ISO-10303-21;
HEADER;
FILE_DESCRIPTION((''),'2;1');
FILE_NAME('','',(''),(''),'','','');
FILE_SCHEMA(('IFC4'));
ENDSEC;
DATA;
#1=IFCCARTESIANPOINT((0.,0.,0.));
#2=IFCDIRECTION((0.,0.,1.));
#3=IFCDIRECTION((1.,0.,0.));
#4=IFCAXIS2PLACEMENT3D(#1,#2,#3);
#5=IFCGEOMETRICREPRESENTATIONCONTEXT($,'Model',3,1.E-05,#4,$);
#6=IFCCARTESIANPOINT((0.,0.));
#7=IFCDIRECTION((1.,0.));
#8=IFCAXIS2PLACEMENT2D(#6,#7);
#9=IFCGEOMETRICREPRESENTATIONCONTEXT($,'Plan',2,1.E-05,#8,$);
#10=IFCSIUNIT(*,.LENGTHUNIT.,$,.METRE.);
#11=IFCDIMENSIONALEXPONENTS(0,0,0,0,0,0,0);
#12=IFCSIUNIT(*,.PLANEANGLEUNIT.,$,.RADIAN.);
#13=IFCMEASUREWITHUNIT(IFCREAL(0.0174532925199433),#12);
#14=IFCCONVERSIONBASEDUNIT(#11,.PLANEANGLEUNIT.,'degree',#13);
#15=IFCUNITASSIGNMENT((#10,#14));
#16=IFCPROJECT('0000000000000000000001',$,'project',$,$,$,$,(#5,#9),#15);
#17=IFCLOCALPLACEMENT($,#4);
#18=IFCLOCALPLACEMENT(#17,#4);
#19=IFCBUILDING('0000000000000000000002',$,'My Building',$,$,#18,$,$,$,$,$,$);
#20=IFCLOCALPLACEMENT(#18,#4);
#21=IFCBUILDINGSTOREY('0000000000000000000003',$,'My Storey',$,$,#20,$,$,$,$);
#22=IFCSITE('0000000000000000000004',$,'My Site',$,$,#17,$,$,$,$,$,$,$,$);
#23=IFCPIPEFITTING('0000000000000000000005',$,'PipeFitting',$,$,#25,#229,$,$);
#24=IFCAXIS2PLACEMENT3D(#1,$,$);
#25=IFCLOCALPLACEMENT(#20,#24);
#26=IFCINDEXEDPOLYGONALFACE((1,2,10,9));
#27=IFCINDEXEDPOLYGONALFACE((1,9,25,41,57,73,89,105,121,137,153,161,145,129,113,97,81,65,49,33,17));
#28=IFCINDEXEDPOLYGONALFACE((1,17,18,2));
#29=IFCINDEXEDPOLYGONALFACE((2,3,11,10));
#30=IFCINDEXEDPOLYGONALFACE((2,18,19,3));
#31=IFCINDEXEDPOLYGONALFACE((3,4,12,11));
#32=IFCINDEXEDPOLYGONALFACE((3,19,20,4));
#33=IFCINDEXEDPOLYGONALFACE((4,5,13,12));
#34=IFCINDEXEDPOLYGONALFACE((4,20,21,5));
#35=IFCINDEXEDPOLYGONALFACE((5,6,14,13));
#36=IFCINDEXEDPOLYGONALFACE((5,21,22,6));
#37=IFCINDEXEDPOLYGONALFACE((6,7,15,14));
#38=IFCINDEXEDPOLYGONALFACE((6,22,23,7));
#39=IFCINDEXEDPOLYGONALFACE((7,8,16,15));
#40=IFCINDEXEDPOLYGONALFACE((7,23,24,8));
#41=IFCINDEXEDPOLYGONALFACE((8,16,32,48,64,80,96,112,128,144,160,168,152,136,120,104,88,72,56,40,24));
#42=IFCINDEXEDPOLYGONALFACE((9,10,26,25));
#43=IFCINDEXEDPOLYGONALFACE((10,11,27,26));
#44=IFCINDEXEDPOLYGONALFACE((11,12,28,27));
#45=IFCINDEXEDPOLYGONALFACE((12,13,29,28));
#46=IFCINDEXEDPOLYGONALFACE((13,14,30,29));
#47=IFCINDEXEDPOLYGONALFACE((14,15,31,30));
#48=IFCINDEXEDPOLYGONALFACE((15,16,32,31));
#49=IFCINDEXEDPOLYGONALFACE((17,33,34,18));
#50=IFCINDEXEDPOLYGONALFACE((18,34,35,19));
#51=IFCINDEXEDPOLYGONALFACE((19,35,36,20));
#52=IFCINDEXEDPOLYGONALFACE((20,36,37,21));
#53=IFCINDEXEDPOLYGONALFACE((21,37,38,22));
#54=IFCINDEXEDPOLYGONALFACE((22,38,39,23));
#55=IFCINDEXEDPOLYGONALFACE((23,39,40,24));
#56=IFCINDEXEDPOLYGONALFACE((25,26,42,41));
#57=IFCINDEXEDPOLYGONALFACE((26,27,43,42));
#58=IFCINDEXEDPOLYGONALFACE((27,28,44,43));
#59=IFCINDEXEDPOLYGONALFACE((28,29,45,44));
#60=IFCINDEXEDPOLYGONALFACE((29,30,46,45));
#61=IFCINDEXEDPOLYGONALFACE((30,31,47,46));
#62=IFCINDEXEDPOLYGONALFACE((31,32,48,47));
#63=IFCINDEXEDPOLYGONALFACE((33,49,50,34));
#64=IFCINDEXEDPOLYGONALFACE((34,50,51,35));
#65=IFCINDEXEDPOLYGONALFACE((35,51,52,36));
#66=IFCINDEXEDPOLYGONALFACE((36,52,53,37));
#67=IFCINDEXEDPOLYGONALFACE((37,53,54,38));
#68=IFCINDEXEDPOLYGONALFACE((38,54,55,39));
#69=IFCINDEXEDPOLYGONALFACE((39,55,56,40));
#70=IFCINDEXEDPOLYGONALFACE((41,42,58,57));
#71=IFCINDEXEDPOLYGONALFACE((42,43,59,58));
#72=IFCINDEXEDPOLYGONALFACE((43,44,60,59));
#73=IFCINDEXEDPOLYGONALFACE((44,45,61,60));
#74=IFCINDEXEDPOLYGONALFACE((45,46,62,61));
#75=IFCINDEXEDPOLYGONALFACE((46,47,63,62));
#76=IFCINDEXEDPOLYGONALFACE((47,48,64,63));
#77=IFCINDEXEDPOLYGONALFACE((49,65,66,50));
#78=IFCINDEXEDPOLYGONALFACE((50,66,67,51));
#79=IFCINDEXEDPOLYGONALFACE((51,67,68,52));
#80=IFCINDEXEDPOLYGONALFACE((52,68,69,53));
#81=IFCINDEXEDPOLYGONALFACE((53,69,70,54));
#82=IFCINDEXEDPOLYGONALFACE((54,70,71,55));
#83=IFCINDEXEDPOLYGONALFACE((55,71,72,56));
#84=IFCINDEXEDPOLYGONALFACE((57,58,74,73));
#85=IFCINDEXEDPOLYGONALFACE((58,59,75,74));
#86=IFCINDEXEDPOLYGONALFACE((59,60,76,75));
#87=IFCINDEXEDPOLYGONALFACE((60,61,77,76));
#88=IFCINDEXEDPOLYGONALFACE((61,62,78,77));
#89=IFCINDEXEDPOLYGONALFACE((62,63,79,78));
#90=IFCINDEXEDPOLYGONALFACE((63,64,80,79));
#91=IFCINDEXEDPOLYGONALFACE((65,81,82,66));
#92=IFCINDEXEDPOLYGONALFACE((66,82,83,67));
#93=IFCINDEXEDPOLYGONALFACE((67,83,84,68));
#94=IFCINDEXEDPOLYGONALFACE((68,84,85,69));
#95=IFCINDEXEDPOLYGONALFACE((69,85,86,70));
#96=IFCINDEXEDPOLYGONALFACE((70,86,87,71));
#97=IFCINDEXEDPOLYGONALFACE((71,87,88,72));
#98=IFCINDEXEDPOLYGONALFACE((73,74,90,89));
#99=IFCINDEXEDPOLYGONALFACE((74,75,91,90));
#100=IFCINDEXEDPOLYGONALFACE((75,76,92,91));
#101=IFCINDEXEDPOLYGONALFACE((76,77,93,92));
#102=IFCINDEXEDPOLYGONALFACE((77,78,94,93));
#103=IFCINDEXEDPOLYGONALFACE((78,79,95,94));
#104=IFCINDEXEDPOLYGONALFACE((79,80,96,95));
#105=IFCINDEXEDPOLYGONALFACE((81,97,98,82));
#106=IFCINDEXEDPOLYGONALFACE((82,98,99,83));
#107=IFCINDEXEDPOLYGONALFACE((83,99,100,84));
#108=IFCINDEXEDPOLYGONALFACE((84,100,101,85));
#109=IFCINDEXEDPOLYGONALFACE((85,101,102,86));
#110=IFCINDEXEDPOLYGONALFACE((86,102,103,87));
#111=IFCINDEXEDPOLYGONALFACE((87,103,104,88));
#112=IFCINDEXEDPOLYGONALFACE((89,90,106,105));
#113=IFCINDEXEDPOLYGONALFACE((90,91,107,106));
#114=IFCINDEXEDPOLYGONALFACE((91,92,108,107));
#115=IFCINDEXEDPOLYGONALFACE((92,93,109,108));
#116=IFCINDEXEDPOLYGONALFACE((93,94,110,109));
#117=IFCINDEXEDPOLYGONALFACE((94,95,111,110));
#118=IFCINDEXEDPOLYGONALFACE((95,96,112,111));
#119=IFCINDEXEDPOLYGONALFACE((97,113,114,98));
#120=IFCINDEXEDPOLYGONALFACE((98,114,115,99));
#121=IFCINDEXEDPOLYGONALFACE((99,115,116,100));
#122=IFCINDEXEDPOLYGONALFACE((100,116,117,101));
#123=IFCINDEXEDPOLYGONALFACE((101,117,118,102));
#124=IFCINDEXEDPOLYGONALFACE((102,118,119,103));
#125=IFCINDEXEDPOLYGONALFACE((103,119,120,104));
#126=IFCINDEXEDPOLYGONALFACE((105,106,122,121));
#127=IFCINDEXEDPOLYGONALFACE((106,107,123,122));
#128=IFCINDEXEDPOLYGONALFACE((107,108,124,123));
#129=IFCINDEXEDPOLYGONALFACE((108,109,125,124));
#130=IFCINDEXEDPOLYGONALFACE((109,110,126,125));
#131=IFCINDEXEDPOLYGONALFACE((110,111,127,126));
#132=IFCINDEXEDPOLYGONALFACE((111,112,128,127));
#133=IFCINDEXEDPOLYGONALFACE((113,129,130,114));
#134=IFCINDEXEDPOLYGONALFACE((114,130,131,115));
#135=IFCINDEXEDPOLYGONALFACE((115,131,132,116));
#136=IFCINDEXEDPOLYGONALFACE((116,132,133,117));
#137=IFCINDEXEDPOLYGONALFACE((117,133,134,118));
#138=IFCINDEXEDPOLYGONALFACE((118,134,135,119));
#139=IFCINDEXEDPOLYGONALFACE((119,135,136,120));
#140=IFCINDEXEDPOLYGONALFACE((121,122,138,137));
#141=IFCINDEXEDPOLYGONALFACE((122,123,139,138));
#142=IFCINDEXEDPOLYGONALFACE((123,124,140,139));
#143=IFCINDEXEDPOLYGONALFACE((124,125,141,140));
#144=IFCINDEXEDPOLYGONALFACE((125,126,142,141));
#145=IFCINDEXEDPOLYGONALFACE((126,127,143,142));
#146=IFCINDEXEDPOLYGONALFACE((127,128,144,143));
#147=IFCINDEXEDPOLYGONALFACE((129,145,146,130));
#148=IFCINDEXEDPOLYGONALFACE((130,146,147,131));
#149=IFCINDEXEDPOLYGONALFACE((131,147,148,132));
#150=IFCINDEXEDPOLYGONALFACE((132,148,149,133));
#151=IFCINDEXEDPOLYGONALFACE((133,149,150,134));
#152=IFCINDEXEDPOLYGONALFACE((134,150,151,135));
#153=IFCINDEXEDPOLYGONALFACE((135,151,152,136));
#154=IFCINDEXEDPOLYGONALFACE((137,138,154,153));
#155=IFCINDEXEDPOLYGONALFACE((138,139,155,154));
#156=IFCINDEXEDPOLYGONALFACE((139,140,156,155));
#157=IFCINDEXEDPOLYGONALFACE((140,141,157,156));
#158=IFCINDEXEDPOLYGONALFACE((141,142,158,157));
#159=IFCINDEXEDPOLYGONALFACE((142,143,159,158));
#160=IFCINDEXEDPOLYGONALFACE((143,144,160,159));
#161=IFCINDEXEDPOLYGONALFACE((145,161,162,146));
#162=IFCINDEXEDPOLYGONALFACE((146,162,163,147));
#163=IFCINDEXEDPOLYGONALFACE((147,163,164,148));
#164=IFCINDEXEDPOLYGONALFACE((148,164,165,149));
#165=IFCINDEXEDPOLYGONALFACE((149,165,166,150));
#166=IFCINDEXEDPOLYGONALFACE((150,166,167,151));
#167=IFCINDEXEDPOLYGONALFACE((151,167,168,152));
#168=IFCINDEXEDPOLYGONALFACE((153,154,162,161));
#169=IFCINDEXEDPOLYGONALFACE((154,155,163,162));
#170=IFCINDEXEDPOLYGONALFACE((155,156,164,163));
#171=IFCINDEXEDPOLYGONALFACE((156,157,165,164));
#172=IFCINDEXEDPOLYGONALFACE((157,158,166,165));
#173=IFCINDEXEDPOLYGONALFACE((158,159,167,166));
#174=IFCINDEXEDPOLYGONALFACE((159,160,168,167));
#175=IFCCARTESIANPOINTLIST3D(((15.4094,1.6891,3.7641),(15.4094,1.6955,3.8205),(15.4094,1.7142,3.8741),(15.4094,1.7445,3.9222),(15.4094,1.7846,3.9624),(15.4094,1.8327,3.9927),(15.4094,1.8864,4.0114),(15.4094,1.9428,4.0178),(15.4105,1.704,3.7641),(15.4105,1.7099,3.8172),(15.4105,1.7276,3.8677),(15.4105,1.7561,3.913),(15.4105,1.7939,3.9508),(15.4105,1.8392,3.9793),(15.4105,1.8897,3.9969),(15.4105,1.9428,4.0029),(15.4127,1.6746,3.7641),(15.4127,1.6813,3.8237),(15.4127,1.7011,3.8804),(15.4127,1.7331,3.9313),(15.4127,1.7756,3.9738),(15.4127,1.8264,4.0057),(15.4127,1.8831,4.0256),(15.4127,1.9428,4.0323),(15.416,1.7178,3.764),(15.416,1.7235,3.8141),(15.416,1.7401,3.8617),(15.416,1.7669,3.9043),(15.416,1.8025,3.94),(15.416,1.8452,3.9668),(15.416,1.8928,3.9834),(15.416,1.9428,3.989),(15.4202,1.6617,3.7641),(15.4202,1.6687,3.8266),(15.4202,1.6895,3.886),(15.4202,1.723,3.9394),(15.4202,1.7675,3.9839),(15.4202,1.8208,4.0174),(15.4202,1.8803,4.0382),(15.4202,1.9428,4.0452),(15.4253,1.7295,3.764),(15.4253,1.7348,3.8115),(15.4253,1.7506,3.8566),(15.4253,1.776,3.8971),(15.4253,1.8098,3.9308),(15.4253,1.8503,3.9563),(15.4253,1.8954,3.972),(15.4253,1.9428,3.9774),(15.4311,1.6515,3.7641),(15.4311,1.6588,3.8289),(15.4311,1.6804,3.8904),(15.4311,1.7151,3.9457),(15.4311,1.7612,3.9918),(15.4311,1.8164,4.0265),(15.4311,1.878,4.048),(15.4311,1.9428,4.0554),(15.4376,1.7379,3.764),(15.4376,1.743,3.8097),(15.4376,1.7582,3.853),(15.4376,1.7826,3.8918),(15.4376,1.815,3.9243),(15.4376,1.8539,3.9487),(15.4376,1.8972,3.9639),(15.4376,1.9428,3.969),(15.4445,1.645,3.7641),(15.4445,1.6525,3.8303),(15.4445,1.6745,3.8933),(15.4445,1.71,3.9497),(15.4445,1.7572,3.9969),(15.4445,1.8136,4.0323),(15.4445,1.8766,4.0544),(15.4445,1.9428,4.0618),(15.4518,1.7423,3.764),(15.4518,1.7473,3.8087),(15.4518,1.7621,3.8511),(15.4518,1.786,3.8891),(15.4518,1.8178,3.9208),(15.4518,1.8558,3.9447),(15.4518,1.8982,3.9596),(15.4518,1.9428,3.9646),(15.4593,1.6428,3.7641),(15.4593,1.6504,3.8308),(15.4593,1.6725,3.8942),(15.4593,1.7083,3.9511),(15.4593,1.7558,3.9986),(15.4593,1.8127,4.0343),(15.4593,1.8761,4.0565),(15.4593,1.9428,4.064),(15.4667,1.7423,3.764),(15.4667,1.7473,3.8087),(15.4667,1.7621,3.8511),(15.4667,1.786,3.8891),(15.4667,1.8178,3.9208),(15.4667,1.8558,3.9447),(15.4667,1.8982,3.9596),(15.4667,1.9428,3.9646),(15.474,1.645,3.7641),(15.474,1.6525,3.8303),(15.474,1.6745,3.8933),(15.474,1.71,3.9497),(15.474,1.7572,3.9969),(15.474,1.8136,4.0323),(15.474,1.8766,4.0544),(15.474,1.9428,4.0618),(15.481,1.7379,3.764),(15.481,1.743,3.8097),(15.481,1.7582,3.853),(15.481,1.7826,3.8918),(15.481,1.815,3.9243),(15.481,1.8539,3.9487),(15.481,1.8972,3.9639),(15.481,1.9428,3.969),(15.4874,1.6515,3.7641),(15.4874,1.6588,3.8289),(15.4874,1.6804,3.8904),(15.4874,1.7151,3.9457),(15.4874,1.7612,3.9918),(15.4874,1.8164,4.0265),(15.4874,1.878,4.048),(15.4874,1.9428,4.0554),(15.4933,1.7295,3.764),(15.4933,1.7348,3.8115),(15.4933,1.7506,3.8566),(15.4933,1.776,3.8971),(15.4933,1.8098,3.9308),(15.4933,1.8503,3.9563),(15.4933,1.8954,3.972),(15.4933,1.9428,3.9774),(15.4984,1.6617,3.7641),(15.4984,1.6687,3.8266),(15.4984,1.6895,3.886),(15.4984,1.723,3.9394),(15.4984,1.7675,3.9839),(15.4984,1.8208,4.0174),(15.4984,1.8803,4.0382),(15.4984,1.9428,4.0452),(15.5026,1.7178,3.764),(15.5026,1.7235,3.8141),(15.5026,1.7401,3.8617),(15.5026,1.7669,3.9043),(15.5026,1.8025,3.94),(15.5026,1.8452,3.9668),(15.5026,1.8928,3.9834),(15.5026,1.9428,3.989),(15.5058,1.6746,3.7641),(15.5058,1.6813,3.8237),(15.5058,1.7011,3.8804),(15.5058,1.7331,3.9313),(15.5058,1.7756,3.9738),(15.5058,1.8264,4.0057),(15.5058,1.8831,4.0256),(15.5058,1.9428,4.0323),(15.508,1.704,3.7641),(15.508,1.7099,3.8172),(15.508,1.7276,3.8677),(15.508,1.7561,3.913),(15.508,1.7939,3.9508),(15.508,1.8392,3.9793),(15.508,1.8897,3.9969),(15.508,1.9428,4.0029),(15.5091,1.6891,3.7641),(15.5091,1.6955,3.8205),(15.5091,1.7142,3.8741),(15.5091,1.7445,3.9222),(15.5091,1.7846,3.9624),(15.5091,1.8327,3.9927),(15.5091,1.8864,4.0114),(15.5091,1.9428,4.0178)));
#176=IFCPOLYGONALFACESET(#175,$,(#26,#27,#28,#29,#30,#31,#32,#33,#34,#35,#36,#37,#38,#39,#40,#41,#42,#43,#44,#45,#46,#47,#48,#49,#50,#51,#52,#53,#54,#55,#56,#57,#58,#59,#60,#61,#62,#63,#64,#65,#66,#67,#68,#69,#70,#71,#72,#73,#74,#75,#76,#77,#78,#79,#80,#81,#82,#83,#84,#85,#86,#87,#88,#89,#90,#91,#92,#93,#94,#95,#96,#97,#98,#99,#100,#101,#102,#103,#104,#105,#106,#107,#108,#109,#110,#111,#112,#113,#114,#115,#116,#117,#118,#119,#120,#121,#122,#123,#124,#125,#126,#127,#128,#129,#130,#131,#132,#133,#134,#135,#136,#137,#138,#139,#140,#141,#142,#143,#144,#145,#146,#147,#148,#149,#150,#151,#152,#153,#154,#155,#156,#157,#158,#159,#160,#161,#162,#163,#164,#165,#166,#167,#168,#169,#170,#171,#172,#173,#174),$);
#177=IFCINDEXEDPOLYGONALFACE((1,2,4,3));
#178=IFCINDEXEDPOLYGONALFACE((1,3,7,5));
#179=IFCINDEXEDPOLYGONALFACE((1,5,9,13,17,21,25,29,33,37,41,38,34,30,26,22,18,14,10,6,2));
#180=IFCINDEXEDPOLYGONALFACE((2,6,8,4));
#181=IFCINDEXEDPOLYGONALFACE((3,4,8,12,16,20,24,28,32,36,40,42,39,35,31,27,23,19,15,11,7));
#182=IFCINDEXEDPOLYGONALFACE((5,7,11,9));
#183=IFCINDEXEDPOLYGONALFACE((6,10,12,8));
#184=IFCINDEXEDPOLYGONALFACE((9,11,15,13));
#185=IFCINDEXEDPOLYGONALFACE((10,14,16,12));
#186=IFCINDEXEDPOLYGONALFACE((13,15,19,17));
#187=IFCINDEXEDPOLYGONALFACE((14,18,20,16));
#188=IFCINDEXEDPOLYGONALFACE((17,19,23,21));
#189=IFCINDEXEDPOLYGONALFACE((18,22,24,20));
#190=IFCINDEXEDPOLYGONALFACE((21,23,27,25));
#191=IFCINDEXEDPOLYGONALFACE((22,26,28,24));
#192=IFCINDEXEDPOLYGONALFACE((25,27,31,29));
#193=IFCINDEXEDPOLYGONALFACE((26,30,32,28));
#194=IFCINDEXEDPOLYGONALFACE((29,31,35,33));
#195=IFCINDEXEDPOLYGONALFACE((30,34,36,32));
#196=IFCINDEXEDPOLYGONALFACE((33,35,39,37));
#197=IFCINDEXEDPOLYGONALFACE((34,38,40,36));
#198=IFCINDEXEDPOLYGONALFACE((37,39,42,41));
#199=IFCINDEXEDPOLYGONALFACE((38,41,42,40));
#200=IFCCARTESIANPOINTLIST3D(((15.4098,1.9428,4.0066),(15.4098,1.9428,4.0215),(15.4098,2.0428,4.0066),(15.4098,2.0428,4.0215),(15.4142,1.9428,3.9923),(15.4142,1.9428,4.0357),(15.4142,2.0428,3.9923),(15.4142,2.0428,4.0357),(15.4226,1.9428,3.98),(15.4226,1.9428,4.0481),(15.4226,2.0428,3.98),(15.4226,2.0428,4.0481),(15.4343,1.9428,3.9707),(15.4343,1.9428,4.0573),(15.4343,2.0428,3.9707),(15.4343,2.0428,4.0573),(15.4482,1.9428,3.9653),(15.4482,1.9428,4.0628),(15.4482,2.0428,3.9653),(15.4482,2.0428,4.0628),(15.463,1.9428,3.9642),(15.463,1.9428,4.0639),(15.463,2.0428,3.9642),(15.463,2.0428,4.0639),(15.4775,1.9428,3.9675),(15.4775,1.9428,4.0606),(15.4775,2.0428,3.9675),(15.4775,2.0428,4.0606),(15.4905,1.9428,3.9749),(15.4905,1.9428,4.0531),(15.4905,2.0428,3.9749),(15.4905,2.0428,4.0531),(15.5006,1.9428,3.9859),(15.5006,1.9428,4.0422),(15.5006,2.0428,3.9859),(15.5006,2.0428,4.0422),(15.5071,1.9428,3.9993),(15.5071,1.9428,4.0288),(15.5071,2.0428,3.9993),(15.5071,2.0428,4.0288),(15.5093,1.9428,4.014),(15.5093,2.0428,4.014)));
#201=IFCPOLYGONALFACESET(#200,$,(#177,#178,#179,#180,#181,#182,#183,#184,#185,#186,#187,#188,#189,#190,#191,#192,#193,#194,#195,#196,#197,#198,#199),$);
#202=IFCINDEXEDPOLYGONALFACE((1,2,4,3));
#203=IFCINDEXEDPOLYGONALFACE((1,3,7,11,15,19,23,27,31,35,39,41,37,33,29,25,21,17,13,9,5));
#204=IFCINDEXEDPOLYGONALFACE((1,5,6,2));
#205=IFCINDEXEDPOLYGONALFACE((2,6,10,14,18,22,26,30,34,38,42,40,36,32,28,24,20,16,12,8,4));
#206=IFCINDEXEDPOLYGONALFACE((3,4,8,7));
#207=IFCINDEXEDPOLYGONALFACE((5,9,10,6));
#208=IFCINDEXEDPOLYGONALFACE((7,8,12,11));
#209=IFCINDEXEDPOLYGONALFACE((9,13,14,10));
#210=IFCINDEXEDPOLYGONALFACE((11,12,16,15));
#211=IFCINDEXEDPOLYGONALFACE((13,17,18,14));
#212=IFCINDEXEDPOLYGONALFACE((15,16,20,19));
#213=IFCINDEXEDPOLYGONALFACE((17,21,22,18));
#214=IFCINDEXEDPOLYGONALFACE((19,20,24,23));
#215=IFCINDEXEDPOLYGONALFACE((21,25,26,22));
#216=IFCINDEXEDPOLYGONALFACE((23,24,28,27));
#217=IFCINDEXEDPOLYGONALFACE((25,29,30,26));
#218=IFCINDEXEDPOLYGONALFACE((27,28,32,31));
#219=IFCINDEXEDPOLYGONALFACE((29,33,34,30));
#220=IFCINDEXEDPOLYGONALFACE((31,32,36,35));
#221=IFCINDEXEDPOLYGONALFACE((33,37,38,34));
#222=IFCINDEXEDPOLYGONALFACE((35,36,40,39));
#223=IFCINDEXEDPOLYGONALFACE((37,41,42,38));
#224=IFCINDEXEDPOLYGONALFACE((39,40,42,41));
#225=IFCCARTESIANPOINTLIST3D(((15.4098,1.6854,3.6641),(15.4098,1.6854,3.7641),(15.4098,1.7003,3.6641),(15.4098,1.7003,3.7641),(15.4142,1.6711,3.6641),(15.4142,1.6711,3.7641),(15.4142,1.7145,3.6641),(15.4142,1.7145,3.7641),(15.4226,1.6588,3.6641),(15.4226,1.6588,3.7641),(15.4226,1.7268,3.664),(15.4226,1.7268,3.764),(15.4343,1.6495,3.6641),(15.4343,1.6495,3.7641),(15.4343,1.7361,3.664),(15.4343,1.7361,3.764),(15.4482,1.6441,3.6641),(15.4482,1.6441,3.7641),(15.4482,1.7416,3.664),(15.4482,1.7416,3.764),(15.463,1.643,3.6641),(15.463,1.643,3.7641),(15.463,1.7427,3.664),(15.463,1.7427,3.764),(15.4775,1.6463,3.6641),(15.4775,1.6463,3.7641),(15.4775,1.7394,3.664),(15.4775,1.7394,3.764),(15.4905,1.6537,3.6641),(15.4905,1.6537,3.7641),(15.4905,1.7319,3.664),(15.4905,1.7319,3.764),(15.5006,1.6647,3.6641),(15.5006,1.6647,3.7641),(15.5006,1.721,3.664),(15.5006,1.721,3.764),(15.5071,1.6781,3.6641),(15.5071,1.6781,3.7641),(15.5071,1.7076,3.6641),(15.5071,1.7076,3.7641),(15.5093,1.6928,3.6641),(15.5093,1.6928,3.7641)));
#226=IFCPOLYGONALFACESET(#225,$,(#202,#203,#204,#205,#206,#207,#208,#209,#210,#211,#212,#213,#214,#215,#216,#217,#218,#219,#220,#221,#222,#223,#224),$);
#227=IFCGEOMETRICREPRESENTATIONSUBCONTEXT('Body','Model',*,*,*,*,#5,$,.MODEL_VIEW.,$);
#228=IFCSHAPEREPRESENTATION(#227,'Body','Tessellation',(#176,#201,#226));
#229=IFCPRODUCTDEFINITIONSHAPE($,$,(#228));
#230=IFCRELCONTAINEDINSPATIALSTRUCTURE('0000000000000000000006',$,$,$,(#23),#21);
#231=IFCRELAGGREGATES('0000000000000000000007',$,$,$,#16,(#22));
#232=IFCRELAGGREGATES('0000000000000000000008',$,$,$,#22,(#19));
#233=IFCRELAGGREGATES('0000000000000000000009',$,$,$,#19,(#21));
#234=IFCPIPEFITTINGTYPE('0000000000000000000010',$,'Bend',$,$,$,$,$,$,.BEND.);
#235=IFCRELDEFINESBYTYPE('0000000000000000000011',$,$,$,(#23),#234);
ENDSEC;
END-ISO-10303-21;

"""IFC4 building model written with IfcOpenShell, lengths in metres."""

from ifc_helpers import new_model, entity, si_unit, converted_unit, frame, origin_with_axes, origin_2d_with_axis, place, context, subcontext, project, spatial, circle, extrude, source, transform, mapped, type_object, type_shapes, element, save


model = new_model("IFC4")

# Units and contexts
model_context = context("Model", 3, precision=1e-05, world=origin_with_axes())
plan_context = context("Plan", 2, precision=1e-05, world=origin_2d_with_axis())
body_context_1 = subcontext(model_context, "Body", "Model", "MODEL_VIEW")
ifc_project = project(units=[si_unit("LENGTHUNIT", "METRE"), converted_unit("PLANEANGLEUNIT", "degree", entity("IfcReal", 0.0174532925199433), si_unit("PLANEANGLEUNIT", "RADIAN"), dimensions=[0, 0, 0, 0, 0, 0, 0])], contexts=[model_context, plan_context])

# Site, building, storey
site_placement = place(None, origin_with_axes())
site = spatial("IfcSite", under=ifc_project, at=site_placement, Name="My Site")
building_placement = place(site_placement, origin_with_axes())
building = spatial("IfcBuilding", under=site, at=building_placement, Name="My Building")
storey_placement = place(building_placement, origin_with_axes())
storey = spatial("IfcBuildingStorey", under=building, at=storey_placement, Name="My Storey")

# Pipe fitting
pipe_fitting_type_1 = type_object("IfcPipeFittingType", Name="Bend", PredefinedType="BEND")
shared_shape_1 = source(origin_with_axes(), body_context_1, "Body", "SolidModel", [
    entity("IfcSweptDiskSolid", entity("IfcIndexedPolyCurve", entity("IfcCartesianPointList3D", [[0.0, 0.0, 0.1], [0.0, -0.0732, 0.2768], [0.0, -0.25, 0.35]]), [entity("IfcArcIndex", [1, 2, 3])]), 0.05),
    extrude(circle(Radius=0.05), origin_with_axes(), (0.0, 0.0, 1.0), 0.1),
    extrude(circle(Radius=0.05), frame((0.0, -0.25, 0.35), z_axis=(0.0, -1.0, 0.000038), x_axis=(1.0, 0.0, 0.0)), (0.0, 0.0, 1.0), 0.1),
])
type_shapes(pipe_fitting_type_1, [shared_shape_1])
for number, where, z_axis, x_axis, name in (
    (1, (15.4593, 2.0428, 4.014), (0.0, -1.0, 0.0), (1.0, 0.0, 0.0), "PipeFitting"),
):
    element("IfcPipeFitting", number, at=place(storey_placement, frame(where, z_axis=z_axis, x_axis=x_axis)), inside=storey, type_object=pipe_fitting_type_1, Name=name, context=body_context_1, shape_type="MappedRepresentation", body=[
        mapped(shared_shape_1, transform((0.0, 0.0, 0.0), x_axis=(1.0, 0.0, 0.0), y_axis=(0.0, 1.0, 0.0), z_axis=(0.0, 0.0, 1.0), scale=1.0)),
    ])

save(model, "model.ifc")
